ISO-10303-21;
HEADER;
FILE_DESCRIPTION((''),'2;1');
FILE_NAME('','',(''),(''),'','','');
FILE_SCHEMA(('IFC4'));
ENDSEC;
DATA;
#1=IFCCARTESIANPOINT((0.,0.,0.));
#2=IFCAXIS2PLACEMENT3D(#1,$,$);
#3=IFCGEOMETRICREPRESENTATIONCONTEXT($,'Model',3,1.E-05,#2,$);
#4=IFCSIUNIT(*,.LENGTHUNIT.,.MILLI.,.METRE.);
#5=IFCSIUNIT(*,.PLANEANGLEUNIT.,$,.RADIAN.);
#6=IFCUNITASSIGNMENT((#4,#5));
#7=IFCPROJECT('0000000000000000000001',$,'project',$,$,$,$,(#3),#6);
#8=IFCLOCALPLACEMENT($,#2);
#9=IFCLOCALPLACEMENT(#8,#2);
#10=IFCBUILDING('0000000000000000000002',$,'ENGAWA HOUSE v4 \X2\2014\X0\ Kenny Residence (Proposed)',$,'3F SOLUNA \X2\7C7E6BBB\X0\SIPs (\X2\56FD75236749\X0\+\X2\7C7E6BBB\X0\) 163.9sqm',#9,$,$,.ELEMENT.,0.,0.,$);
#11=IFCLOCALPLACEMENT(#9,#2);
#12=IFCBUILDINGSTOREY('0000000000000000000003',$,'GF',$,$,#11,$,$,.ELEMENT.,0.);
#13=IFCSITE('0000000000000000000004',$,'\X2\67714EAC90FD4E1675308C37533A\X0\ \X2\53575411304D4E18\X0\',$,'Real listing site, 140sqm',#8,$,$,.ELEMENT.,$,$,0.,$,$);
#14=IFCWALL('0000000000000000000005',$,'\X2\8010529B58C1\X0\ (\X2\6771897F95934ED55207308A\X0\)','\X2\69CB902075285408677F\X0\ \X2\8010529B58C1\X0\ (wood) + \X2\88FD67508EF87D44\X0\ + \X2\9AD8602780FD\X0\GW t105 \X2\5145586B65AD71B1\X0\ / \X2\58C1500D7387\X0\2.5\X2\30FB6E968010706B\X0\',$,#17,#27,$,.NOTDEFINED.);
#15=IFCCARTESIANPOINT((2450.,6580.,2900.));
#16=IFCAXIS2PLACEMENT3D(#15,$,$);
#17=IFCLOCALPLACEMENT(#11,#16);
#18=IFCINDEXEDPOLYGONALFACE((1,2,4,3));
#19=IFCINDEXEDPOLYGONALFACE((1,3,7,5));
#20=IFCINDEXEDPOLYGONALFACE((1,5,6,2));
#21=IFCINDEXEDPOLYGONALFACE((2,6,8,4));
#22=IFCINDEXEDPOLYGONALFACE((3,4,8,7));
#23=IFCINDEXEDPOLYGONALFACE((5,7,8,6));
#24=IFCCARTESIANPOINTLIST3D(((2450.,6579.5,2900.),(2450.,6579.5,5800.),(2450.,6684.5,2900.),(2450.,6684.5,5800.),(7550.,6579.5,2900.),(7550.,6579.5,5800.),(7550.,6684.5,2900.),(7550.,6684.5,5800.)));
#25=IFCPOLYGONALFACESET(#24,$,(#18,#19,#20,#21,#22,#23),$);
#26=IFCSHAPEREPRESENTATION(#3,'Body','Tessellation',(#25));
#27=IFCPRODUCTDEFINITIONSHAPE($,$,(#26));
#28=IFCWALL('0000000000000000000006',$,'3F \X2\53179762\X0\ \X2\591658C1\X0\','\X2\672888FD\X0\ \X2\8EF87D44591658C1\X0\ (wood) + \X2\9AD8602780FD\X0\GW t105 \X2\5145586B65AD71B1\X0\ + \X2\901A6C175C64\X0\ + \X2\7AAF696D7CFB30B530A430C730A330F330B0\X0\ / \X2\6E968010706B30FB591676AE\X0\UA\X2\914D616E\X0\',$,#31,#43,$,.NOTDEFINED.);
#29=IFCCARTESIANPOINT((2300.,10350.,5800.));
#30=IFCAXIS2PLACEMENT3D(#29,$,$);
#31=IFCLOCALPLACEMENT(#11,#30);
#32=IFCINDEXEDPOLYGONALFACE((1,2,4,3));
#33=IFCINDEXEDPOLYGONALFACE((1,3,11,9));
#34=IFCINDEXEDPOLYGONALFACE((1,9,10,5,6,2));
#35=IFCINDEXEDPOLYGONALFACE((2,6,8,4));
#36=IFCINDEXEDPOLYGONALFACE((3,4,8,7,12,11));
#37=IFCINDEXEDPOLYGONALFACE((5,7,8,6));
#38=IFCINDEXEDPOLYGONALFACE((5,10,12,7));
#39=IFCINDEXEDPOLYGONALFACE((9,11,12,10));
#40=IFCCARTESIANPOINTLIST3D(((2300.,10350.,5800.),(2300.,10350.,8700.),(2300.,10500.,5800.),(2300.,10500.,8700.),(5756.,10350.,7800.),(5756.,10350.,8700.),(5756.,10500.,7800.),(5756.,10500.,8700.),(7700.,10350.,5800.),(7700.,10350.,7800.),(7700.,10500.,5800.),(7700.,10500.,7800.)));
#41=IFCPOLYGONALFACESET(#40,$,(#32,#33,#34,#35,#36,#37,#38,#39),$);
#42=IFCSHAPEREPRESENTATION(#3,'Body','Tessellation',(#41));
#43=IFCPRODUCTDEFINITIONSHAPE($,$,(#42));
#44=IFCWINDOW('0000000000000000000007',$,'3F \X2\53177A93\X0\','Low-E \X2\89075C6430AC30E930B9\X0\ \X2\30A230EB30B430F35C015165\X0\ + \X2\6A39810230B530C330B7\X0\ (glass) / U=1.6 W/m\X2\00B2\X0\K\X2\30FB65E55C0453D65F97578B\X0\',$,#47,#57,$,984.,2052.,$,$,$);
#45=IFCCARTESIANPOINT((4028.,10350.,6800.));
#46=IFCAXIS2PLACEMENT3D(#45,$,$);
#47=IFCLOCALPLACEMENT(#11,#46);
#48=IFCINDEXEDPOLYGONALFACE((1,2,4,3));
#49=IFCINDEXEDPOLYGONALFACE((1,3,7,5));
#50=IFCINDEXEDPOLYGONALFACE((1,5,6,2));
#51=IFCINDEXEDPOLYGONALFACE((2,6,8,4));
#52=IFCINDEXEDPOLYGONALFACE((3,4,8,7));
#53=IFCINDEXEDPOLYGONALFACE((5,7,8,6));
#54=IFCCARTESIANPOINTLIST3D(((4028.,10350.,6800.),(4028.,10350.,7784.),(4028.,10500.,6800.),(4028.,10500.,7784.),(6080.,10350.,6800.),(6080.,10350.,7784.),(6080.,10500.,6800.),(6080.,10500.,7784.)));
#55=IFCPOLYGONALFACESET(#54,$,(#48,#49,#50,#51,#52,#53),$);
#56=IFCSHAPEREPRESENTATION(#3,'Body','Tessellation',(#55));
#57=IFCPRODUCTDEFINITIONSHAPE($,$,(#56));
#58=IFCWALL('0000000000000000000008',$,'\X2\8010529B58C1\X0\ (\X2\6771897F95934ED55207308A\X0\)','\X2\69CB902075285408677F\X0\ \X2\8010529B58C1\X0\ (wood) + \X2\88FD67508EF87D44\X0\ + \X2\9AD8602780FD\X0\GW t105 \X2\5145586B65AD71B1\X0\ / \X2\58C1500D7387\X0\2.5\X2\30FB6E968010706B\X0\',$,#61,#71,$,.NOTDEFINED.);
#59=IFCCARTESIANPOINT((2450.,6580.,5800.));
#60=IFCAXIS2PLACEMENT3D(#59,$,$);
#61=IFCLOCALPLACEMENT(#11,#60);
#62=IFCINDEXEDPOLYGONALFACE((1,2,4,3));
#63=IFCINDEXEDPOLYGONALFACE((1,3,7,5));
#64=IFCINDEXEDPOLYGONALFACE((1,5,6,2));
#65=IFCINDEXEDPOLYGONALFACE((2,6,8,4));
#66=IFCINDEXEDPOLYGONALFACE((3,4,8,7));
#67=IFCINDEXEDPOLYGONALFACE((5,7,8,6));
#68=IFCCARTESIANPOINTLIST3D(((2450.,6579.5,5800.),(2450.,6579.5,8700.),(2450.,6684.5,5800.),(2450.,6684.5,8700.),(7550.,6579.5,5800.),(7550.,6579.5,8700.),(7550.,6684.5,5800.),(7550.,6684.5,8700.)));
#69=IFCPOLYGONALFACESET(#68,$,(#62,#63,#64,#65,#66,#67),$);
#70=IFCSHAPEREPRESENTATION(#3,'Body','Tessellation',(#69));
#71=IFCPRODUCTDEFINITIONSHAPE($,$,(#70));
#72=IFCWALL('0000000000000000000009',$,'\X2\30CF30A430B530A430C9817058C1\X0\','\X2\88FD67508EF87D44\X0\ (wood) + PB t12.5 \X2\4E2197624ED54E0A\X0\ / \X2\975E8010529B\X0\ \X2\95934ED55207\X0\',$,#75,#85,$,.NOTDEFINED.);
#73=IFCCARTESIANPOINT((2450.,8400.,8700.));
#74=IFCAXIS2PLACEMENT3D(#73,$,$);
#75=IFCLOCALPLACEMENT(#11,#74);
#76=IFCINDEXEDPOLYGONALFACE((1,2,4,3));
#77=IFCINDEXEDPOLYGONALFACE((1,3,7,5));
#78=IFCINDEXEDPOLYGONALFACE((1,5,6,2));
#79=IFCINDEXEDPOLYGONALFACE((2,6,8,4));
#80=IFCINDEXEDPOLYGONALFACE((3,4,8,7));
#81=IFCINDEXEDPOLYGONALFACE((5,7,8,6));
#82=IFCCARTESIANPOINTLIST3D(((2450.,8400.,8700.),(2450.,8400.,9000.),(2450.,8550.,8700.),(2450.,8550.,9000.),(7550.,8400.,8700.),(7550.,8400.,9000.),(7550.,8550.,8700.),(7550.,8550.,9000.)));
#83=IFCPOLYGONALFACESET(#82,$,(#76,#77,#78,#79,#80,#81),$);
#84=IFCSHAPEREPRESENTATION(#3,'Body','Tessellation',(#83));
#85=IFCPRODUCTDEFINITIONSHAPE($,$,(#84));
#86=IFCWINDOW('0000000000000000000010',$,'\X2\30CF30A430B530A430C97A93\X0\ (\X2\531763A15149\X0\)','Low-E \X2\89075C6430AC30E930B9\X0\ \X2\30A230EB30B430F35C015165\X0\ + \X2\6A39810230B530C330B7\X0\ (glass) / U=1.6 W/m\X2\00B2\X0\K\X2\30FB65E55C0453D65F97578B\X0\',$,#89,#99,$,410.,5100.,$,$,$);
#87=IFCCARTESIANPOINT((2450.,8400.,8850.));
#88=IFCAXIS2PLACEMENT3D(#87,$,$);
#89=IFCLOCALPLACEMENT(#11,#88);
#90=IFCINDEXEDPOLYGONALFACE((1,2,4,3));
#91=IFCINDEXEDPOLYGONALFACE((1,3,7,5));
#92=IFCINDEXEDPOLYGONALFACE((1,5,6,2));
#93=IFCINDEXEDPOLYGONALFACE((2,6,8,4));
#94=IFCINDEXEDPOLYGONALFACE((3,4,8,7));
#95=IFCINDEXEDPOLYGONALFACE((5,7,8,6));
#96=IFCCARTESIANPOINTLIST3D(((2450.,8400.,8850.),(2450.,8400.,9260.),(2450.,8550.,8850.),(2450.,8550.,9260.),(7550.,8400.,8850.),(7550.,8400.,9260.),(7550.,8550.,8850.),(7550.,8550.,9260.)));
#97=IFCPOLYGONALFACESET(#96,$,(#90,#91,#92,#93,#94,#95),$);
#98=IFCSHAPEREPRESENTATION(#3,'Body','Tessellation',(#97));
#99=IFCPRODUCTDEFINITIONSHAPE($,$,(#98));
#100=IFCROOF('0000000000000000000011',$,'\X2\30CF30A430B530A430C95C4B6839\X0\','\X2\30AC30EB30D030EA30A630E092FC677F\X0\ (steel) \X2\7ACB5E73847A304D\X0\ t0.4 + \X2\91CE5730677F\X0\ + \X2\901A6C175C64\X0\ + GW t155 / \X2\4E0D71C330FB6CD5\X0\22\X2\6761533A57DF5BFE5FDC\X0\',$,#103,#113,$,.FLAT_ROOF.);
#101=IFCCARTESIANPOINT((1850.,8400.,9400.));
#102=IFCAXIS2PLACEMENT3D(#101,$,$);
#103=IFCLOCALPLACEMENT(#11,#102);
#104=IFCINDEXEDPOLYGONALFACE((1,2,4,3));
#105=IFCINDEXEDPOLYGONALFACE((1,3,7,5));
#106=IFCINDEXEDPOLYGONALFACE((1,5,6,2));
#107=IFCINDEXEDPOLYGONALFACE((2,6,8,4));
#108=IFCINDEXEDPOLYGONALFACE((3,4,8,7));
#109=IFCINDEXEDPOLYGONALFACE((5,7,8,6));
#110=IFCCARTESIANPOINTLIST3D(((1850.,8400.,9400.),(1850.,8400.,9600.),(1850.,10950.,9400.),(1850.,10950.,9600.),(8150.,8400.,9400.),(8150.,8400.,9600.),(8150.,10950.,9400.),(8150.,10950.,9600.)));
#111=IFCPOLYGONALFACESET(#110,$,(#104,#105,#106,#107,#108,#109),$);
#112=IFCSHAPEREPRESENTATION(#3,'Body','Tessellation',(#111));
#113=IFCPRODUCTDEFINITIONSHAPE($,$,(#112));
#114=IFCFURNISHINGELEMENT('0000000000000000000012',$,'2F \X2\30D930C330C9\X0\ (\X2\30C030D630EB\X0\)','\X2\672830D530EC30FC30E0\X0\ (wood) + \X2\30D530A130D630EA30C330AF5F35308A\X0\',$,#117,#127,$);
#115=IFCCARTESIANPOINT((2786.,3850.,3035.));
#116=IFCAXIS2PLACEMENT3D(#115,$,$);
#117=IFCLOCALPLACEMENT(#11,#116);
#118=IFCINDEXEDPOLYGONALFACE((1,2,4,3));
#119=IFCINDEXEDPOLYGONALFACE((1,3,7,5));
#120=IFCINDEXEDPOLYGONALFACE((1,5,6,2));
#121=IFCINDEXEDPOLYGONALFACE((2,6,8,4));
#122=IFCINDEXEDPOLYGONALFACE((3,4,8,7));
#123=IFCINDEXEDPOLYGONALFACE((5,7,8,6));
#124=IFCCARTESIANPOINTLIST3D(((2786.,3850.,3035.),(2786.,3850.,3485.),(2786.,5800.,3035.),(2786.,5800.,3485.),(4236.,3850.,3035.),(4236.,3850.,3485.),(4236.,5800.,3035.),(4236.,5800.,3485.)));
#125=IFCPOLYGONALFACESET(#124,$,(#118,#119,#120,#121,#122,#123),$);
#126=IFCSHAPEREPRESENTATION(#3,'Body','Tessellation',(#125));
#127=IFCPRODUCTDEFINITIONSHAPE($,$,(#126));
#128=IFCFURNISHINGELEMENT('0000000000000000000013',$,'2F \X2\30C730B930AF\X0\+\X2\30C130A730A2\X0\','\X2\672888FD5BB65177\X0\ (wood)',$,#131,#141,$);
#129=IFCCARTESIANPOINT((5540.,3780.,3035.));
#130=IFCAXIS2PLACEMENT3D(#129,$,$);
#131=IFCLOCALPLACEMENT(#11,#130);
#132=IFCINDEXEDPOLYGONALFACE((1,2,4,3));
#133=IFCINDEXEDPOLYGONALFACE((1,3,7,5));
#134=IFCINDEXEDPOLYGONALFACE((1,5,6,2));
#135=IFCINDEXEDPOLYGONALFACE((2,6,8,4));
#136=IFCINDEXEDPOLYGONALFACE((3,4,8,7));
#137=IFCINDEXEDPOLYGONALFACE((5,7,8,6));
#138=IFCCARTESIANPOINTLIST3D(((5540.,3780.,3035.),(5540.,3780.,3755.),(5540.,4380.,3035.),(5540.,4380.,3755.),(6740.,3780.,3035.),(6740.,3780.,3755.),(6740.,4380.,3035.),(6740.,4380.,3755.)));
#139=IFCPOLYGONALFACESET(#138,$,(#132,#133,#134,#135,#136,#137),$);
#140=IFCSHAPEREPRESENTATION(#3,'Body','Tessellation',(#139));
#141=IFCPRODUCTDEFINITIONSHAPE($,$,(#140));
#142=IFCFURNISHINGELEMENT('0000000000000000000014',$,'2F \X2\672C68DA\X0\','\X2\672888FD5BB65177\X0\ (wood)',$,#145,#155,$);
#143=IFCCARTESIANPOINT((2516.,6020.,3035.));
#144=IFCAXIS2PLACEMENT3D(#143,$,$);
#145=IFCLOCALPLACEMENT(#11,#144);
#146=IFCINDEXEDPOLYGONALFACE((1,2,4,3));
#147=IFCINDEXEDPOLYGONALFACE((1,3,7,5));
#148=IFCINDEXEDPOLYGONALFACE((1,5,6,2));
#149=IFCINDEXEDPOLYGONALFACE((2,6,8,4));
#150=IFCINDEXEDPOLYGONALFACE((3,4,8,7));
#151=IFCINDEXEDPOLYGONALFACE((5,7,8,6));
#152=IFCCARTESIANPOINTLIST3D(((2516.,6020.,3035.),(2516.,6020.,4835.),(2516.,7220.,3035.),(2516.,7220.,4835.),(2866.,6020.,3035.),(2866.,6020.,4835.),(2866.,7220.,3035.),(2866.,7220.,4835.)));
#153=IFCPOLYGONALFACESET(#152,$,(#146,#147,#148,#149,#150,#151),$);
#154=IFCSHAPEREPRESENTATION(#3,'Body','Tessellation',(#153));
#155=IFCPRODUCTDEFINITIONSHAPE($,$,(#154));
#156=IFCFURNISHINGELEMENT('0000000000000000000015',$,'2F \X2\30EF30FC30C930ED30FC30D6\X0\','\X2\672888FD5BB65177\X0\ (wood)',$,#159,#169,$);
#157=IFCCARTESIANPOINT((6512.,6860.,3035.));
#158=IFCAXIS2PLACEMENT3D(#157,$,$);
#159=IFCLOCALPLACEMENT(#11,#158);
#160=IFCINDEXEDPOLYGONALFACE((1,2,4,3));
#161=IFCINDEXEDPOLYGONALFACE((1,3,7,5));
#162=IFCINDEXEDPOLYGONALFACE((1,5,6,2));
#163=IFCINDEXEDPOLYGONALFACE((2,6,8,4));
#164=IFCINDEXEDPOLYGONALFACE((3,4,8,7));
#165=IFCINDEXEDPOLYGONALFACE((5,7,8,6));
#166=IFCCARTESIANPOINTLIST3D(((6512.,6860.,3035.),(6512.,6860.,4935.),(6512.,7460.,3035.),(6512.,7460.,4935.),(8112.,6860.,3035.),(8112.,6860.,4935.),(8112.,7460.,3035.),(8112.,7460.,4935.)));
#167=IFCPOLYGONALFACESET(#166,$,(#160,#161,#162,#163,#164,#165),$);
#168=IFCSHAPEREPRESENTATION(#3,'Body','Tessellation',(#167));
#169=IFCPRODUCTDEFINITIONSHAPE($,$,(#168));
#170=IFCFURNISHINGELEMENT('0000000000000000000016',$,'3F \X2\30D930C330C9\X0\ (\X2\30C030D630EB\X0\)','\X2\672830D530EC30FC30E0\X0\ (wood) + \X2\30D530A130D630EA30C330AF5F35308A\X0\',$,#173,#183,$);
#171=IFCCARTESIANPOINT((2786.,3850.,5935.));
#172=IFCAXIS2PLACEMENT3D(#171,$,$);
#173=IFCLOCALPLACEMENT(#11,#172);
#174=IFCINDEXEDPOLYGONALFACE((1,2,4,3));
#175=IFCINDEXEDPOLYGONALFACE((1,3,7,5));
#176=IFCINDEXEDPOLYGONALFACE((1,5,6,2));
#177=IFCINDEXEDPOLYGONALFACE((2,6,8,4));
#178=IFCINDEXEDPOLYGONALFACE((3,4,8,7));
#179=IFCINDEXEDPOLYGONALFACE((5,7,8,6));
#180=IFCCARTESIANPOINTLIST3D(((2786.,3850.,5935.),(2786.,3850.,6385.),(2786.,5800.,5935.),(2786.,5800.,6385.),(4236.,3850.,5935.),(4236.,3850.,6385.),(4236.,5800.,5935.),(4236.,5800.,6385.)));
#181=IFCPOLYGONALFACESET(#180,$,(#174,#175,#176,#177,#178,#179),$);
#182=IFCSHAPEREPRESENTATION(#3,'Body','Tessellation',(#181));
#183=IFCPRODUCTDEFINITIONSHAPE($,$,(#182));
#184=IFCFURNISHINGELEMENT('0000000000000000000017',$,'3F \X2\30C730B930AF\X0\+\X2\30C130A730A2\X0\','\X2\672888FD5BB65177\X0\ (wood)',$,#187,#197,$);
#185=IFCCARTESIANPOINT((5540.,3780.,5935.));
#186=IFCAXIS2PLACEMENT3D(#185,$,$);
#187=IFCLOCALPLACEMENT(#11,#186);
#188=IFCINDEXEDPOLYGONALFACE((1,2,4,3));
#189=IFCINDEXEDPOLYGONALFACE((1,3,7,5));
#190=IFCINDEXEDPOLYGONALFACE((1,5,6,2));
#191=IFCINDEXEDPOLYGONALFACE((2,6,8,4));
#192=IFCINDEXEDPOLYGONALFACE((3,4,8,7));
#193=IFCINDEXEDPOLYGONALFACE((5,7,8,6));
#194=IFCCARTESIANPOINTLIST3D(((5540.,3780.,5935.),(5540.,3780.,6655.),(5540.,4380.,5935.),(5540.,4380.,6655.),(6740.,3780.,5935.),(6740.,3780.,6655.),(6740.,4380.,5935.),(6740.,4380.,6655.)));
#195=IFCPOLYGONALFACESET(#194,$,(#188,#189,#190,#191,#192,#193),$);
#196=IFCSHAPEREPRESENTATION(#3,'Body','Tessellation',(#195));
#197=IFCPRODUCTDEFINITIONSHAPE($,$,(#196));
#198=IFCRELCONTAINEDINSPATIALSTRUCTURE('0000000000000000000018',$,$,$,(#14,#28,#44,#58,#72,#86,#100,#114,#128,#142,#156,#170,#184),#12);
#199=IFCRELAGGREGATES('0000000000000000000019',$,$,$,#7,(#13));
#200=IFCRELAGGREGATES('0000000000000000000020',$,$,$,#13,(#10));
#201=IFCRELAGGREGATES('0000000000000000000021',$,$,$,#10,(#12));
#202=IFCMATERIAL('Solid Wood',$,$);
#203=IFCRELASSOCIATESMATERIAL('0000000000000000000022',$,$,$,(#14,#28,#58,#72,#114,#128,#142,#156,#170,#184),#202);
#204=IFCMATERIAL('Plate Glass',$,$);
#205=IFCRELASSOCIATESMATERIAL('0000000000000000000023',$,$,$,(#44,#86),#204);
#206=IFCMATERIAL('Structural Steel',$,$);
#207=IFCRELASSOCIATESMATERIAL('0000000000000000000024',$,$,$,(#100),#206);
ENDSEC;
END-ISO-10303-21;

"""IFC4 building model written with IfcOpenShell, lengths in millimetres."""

from ifc_helpers import new_model, si_unit, frame, frame_2d, origin, place, context, project, spatial, rectangle, extrude, material, element, fill, save


model = new_model("IFC4")

# Units and contexts
model_context = context("Model", 3, precision=1e-05, world=origin())
ifc_project = project(units=[si_unit("LENGTHUNIT", "METRE", prefix="MILLI"), si_unit("PLANEANGLEUNIT", "RADIAN")], contexts=[model_context])

# Site, building, storey
site_placement = place(None, origin())
site = spatial("IfcSite", under=ifc_project, at=site_placement, Name="東京都世田谷区 南向き丘", ObjectType="Real listing site, 140sqm", CompositionType="ELEMENT", RefElevation=0.0)
building_placement = place(site_placement, origin())
building = spatial("IfcBuilding", under=site, at=building_placement, Name="ENGAWA HOUSE v4 — Kenny Residence (Proposed)", ObjectType="3F SOLUNA 籾殻SIPs (国産杉+籾殻) 163.9sqm", CompositionType="ELEMENT", ElevationOfRefHeight=0.0, ElevationOfTerrain=0.0)
storey_placement = place(building_placement, origin())
storey = spatial("IfcBuildingStorey", under=building, at=storey_placement, Name="GF", CompositionType="ELEMENT", Elevation=0.0)

# Wall
ifc_material_1 = material(Name="Solid Wood")
wall_1_placement = place(storey_placement, frame((2450.0, 6580.0, 2900.0)))
element("IfcWall", 1, at=wall_1_placement, inside=storey, material=ifc_material_1, Name="耐力壁 (東西間仕切り)", Description="構造用合板 耐力壁 (wood) + 製材軸組 + 高性能GW t105 充填断熱 / 壁倍率2.5・準耐火", PredefinedType="NOTDEFINED", context=model_context, shape_type="SweptSolid", body=[
    extrude(rectangle(XDim=5100.0, YDim=105.0, at=frame_2d((2550.0, 52.0))), frame((2450.0, 6580.0, 2900.0)), (0.0, 0.0, 1.0), 2900.0),
])

# Wall, opening, window
wall_2_placement = place(storey_placement, frame((2300.0, 10350.0, 5800.0)))
wall_2 = element("IfcWall", 2, at=wall_2_placement, inside=storey, material=ifc_material_1, Name="3F 北面 外壁", Description="木製 軸組外壁 (wood) + 高性能GW t105 充填断熱 + 通気層 + 窯業系サイディング / 準耐火・外皮UA配慮", PredefinedType="NOTDEFINED", context=model_context, shape_type="SweptSolid", body=[
    extrude(rectangle(XDim=5400.0, YDim=150.0, at=frame_2d((2700.0, 75.0))), frame((2300.0, 10350.0, 5800.0)), (0.0, 0.0, 1.0), 2900.0),
])
opening_1_placement = place(storey_placement, frame((4028.0, 10350.0, 6800.0)))
opening_1 = element("IfcOpeningElement", 3, at=opening_1_placement, cuts=wall_2, PredefinedType="NOTDEFINED", context=model_context, shape_type="SweptSolid", body=[
    extrude(rectangle(XDim=2052.0, YDim=150.0, at=frame_2d((1026.0, 75.0))), frame((4028.0, 10350.0, 6800.0)), (0.0, 0.0, 1.0), 984.0),
])
ifc_material_2 = material(Name="Plate Glass")
window_1_placement = place(storey_placement, frame((4028.0, 10350.0, 6800.0)))
window_1 = element("IfcWindow", 4, at=window_1_placement, inside=storey, material=ifc_material_2, Name="3F 北窓", Description="Low-E 複層ガラス アルゴン封入 + 樹脂サッシ (glass) / U=1.6 W/m²K・日射取得型", OverallHeight=984.0, OverallWidth=2052.0, context=model_context, shape_type="SweptSolid", body=[
    extrude(rectangle(XDim=2052.0, YDim=150.0, at=frame_2d((1026.0, 75.0))), frame((4028.0, 10350.0, 6800.0)), (0.0, 0.0, 1.0), 984.0),
])
fill(opening_1, window_1)

# Wall
wall_3_placement = place(storey_placement, frame((2450.0, 6580.0, 5800.0)))
element("IfcWall", 5, at=wall_3_placement, inside=storey, material=ifc_material_1, Name="耐力壁 (東西間仕切り)", Description="構造用合板 耐力壁 (wood) + 製材軸組 + 高性能GW t105 充填断熱 / 壁倍率2.5・準耐火", PredefinedType="NOTDEFINED", context=model_context, shape_type="SweptSolid", body=[
    extrude(rectangle(XDim=5100.0, YDim=105.0, at=frame_2d((2550.0, 52.0))), frame((2450.0, 6580.0, 5800.0)), (0.0, 0.0, 1.0), 2900.0),
])

# Wall, opening, window
wall_4_placement = place(storey_placement, frame((2450.0, 8400.0, 8700.0)))
wall_4 = element("IfcWall", 6, at=wall_4_placement, inside=storey, material=ifc_material_1, Name="ハイサイド腰壁", Description="製材軸組 (wood) + PB t12.5 両面仕上 / 非耐力 間仕切", PredefinedType="NOTDEFINED", context=model_context, shape_type="SweptSolid", body=[
    extrude(rectangle(XDim=5100.0, YDim=150.0, at=frame_2d((2550.0, 75.0))), frame((2450.0, 8400.0, 8700.0)), (0.0, 0.0, 1.0), 700.0),
])
opening_2_placement = place(storey_placement, frame((2450.0, 8400.0, 8850.0)))
opening_2 = element("IfcOpeningElement", 7, at=opening_2_placement, cuts=wall_4, PredefinedType="NOTDEFINED", context=model_context, shape_type="SweptSolid", body=[
    extrude(rectangle(XDim=5100.0, YDim=150.0, at=frame_2d((2550.0, 75.0))), frame((2450.0, 8400.0, 8850.0)), (0.0, 0.0, 1.0), 410.0),
])
window_2_placement = place(storey_placement, frame((2450.0, 8400.0, 8850.0)))
window_2 = element("IfcWindow", 8, at=window_2_placement, inside=storey, material=ifc_material_2, Name="ハイサイド窓 (北採光)", Description="Low-E 複層ガラス アルゴン封入 + 樹脂サッシ (glass) / U=1.6 W/m²K・日射取得型", OverallHeight=410.0, OverallWidth=5100.0, context=model_context, shape_type="SweptSolid", body=[
    extrude(rectangle(XDim=5100.0, YDim=150.0, at=frame_2d((2550.0, 75.0))), frame((2450.0, 8400.0, 8850.0)), (0.0, 0.0, 1.0), 410.0),
])
fill(opening_2, window_2)

# Roof
ifc_material_3 = material(Name="Structural Steel")
roof_placement = place(storey_placement, frame((1850.0, 8400.0, 9400.0)))
element("IfcRoof", 9, at=roof_placement, inside=storey, material=ifc_material_3, Name="ハイサイド屋根", Description="ガルバリウム鋼板 (steel) 立平葺き t0.4 + 野地板 + 通気層 + GW t155 / 不燃・法22条区域対応", PredefinedType="FLAT_ROOF", context=model_context, shape_type="SweptSolid", body=[
    extrude(rectangle(XDim=6300.0, YDim=2550.0, at=frame_2d((3150.0, 1275.0))), frame((1850.0, 8400.0, 9400.0)), (0.0, 0.0, 1.0), 200.0),
])

# Furnishing elements
furnishing_1_placement = place(storey_placement, frame((2786.0, 3850.0, 3035.0)))
element("IfcFurnishingElement", 10, at=furnishing_1_placement, inside=storey, material=ifc_material_1, Name="2F ベッド (ダブル)", Description="木フレーム (wood) + ファブリック張り", context=model_context, shape_type="SweptSolid", body=[
    extrude(rectangle(XDim=1450.0, YDim=1950.0, at=frame_2d((725.0, 975.0))), frame((2786.0, 3850.0, 3035.0)), (0.0, 0.0, 1.0), 450.0),
])
furnishing_2_placement = place(storey_placement, frame((5540.0, 3780.0, 3035.0)))
element("IfcFurnishingElement", 11, at=furnishing_2_placement, inside=storey, material=ifc_material_1, Name="2F デスク+チェア", Description="木製家具 (wood)", context=model_context, shape_type="SweptSolid", body=[
    extrude(rectangle(XDim=1200.0, YDim=600.0, at=frame_2d((600.0, 300.0))), frame((5540.0, 3780.0, 3035.0)), (0.0, 0.0, 1.0), 720.0),
])
furnishing_3_placement = place(storey_placement, frame((2516.0, 6020.0, 3035.0)))
element("IfcFurnishingElement", 12, at=furnishing_3_placement, inside=storey, material=ifc_material_1, Name="2F 本棚", Description="木製家具 (wood)", context=model_context, shape_type="SweptSolid", body=[
    extrude(rectangle(XDim=350.0, YDim=1200.0, at=frame_2d((175.0, 600.0))), frame((2516.0, 6020.0, 3035.0)), (0.0, 0.0, 1.0), 1800.0),
])
furnishing_4_placement = place(storey_placement, frame((6512.0, 6860.0, 3035.0)))
element("IfcFurnishingElement", 13, at=furnishing_4_placement, inside=storey, material=ifc_material_1, Name="2F ワードローブ", Description="木製家具 (wood)", context=model_context, shape_type="SweptSolid", body=[
    extrude(rectangle(XDim=1600.0, YDim=600.0, at=frame_2d((800.0, 300.0))), frame((6512.0, 6860.0, 3035.0)), (0.0, 0.0, 1.0), 1900.0),
])
furnishing_5_placement = place(storey_placement, frame((2786.0, 3850.0, 5935.0)))
element("IfcFurnishingElement", 14, at=furnishing_5_placement, inside=storey, material=ifc_material_1, Name="3F ベッド (ダブル)", Description="木フレーム (wood) + ファブリック張り", context=model_context, shape_type="SweptSolid", body=[
    extrude(rectangle(XDim=1450.0, YDim=1950.0, at=frame_2d((725.0, 975.0))), frame((2786.0, 3850.0, 5935.0)), (0.0, 0.0, 1.0), 450.0),
])
furnishing_6_placement = place(storey_placement, frame((5540.0, 3780.0, 5935.0)))
element("IfcFurnishingElement", 15, at=furnishing_6_placement, inside=storey, material=ifc_material_1, Name="3F デスク+チェア", Description="木製家具 (wood)", context=model_context, shape_type="SweptSolid", body=[
    extrude(rectangle(XDim=1200.0, YDim=600.0, at=frame_2d((600.0, 300.0))), frame((5540.0, 3780.0, 5935.0)), (0.0, 0.0, 1.0), 720.0),
])

save(model, "model.ifc")
